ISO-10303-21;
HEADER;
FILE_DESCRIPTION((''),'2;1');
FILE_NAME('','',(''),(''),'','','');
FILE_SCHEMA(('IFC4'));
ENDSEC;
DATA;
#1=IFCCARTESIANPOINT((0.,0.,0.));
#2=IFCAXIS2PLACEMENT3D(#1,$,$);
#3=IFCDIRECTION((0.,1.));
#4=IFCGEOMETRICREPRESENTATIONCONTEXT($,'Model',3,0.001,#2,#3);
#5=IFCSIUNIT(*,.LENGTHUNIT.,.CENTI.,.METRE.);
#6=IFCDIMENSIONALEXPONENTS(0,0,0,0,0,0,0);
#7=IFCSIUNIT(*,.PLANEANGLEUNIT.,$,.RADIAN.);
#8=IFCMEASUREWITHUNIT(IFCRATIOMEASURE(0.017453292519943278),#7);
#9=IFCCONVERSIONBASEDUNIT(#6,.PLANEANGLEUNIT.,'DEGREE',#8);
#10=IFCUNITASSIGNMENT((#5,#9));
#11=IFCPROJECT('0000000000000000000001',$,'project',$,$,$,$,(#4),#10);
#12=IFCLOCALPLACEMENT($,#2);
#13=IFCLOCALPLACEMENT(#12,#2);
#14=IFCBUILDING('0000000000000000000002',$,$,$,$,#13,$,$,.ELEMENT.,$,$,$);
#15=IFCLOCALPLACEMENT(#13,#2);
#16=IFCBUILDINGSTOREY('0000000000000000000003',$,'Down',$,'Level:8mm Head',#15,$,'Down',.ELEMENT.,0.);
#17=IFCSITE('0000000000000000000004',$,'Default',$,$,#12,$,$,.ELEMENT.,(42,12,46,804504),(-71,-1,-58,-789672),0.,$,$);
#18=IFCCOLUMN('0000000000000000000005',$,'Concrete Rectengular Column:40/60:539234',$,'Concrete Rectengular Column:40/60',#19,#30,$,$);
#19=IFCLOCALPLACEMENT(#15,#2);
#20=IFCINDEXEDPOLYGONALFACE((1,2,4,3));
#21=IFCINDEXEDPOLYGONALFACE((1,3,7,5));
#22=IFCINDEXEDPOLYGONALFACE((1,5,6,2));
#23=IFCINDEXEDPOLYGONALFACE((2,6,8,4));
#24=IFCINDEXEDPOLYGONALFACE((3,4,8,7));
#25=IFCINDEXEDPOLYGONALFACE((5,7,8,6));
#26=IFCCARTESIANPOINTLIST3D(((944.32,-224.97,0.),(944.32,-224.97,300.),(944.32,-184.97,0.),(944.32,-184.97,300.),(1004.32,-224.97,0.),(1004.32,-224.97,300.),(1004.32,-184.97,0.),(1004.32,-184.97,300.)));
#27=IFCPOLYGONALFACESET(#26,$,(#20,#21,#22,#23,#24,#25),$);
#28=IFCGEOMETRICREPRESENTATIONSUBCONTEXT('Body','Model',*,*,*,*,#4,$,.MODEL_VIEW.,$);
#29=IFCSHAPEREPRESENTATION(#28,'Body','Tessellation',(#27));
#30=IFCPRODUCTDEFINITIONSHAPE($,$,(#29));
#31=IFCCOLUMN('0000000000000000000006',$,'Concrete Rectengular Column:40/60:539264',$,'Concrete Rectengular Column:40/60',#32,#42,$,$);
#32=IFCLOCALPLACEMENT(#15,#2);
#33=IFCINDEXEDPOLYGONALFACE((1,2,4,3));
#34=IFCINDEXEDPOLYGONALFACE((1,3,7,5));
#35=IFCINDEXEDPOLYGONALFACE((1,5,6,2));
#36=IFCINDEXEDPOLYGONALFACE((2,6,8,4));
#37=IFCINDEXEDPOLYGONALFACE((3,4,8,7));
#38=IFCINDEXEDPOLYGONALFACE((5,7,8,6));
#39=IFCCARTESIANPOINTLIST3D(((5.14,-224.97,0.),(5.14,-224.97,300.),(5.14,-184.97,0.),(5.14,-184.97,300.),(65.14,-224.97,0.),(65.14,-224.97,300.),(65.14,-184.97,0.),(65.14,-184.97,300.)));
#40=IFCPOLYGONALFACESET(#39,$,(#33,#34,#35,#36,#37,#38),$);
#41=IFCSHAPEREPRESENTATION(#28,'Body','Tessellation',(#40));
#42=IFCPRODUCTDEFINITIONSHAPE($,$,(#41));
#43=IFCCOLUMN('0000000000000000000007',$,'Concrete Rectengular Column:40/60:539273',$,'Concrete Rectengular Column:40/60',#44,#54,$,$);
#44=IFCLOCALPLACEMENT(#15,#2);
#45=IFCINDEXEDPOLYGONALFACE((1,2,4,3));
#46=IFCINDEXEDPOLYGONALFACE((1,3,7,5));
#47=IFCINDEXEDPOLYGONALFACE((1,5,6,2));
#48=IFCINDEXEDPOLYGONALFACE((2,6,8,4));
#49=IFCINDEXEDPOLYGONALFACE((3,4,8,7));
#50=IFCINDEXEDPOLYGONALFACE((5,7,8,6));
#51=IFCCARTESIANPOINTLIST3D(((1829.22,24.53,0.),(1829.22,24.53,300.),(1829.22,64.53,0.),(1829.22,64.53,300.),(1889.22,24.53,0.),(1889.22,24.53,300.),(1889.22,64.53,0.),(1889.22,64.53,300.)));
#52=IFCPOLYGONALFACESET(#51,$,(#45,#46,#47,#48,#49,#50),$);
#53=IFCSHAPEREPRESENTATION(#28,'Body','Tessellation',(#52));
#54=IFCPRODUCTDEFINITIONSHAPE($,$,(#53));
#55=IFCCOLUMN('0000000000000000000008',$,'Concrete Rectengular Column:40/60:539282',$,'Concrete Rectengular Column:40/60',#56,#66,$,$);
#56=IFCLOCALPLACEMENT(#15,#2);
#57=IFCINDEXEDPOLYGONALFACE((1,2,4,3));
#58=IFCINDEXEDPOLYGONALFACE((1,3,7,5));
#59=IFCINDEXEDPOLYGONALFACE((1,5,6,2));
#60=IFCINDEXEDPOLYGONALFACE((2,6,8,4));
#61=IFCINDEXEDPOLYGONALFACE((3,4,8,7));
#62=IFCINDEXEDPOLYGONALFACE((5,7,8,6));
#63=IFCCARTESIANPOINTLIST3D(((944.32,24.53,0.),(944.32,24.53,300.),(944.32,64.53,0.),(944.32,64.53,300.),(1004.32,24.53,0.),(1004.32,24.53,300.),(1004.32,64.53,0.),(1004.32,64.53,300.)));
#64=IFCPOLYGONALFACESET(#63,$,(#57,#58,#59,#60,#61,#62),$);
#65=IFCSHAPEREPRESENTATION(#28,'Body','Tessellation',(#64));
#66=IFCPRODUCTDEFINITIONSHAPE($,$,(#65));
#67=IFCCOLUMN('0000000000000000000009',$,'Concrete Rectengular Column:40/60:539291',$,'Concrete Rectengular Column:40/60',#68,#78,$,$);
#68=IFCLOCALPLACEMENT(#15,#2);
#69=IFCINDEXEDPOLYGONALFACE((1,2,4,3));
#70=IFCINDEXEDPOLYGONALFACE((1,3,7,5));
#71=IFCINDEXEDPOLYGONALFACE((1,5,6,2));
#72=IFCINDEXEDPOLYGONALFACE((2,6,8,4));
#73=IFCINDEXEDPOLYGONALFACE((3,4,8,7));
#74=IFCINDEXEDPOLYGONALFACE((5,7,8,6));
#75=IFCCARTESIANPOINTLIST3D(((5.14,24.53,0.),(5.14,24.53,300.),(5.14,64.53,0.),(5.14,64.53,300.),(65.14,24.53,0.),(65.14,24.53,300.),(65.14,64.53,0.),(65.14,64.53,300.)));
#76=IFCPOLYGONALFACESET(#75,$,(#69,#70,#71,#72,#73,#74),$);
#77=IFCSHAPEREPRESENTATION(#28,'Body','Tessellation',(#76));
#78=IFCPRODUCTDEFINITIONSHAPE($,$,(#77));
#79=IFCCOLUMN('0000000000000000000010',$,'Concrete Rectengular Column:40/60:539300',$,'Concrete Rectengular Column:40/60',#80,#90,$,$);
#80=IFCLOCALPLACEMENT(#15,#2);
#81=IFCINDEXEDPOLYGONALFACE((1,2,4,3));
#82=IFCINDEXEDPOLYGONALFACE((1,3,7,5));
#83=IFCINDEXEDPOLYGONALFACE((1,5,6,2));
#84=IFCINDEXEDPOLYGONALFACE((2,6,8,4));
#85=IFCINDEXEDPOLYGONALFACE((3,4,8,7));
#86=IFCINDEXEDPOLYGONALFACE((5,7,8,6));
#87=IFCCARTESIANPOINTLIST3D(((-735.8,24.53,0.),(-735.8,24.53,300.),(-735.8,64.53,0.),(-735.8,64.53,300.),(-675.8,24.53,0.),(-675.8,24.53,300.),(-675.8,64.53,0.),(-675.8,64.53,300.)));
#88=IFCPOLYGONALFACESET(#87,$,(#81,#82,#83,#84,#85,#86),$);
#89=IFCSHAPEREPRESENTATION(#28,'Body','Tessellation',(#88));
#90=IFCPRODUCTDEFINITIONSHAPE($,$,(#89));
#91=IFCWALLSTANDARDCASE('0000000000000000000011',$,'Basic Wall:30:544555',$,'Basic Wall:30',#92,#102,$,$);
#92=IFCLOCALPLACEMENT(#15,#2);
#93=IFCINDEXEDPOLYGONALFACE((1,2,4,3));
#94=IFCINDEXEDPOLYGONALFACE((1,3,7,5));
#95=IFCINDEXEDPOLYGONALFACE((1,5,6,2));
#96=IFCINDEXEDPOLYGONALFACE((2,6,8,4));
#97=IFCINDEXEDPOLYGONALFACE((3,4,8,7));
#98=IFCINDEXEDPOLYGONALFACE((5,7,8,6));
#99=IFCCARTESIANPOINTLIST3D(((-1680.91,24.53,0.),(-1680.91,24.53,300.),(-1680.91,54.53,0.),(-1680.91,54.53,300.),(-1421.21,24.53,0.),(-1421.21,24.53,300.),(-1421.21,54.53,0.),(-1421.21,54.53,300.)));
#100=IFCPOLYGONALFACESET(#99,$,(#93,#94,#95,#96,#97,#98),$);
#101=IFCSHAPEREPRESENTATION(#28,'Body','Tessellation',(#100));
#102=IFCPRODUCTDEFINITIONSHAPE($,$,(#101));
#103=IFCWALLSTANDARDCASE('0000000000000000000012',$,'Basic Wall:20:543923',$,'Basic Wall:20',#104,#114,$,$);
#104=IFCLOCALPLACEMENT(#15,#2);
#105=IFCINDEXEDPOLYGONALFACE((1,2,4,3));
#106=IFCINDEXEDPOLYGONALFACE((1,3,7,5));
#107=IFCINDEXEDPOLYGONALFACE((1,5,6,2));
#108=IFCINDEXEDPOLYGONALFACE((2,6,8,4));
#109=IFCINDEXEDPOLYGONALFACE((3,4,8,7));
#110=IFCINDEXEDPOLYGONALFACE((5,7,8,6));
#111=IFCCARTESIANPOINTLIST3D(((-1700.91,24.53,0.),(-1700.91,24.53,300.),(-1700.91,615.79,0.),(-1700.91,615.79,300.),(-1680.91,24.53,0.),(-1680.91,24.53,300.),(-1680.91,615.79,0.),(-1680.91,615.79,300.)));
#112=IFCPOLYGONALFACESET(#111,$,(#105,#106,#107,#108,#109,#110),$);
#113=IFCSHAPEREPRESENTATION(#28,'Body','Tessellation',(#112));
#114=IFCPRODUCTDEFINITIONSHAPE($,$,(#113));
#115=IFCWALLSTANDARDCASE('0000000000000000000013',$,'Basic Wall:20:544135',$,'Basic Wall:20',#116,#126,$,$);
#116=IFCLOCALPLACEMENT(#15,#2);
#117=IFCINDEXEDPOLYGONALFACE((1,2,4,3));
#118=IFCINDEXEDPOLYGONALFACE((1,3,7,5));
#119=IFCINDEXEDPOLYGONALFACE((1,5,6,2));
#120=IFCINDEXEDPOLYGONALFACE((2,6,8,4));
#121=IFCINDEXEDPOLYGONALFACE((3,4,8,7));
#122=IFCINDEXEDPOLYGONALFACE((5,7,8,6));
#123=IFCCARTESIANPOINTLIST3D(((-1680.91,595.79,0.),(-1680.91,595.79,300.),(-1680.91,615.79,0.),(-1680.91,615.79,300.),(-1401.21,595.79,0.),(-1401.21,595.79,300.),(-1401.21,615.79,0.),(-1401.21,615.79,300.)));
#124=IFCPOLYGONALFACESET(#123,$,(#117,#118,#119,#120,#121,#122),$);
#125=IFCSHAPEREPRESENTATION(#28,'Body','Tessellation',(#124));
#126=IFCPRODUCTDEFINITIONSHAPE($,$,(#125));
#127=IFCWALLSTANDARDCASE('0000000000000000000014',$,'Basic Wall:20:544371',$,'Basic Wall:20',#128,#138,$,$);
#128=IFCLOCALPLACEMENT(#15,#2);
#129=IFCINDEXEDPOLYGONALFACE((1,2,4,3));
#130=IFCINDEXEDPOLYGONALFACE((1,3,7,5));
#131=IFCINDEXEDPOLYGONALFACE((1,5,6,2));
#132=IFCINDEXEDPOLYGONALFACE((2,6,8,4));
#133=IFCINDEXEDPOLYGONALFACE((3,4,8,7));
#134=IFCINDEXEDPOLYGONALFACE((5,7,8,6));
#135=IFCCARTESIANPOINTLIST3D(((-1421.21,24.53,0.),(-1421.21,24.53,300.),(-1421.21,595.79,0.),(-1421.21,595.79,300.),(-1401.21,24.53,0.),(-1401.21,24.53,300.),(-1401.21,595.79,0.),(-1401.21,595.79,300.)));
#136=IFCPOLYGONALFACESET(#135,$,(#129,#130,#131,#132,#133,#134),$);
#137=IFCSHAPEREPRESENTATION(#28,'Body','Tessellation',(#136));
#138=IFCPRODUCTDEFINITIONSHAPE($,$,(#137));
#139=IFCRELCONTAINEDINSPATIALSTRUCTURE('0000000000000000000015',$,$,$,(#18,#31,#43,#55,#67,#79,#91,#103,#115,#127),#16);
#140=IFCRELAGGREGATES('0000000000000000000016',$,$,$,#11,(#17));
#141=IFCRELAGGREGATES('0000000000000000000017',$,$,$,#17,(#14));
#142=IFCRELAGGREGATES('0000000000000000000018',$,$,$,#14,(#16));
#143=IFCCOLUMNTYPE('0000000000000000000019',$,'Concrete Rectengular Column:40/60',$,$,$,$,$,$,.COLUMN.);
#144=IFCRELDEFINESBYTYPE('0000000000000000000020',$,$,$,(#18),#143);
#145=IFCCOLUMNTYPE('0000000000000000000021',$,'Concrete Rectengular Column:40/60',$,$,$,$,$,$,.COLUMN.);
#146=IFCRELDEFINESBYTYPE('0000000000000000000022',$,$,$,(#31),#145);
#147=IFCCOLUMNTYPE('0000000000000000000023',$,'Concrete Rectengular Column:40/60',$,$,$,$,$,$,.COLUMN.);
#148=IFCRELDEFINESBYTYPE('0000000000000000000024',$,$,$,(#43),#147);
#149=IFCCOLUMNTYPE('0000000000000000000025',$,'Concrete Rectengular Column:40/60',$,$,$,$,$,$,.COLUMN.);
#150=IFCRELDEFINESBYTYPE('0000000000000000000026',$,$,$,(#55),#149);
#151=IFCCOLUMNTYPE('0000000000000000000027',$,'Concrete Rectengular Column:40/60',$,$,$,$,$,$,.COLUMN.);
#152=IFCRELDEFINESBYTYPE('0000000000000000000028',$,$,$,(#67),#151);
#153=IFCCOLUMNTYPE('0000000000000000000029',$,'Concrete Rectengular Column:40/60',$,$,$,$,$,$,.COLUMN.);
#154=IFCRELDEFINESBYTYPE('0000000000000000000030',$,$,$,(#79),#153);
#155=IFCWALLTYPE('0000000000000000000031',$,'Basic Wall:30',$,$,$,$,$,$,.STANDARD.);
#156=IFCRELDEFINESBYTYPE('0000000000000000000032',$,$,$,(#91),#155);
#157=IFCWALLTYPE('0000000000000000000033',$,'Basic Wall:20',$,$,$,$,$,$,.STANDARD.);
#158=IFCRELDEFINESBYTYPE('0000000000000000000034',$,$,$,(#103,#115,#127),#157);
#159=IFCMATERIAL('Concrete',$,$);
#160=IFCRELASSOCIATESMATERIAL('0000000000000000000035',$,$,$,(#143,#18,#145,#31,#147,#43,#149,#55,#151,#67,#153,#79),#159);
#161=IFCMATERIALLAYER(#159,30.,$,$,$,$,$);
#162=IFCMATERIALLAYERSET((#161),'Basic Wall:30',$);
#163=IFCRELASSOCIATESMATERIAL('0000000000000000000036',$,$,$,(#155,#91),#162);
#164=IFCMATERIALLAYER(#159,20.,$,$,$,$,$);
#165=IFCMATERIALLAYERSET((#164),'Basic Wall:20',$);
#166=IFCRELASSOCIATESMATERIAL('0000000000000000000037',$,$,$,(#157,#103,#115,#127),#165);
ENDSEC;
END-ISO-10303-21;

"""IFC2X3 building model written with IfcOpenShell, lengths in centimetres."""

from ifc_helpers import new_model, entity, si_unit, converted_unit, direction, frame, frame_2d, origin, origin_2d_with_axis, place, context, subcontext, project, spatial, rectangle, extrude, source, transform, mapped, material, layer, layer_set, layer_usage, type_object, type_shapes, element, save


model = new_model("IFC2X3")

# Units and contexts
model_context = context("Model", 3, precision=0.001, world=origin(), true_north=direction((0.0, 1.0)))
body_context = subcontext(model_context, "Body", "Model", "MODEL_VIEW")
ifc_project = project(units=[si_unit("LENGTHUNIT", "METRE", prefix="CENTI"), converted_unit("PLANEANGLEUNIT", "DEGREE", entity("IfcRatioMeasure", 0.017453292519943278), si_unit("PLANEANGLEUNIT", "RADIAN"), dimensions=[0, 0, 0, 0, 0, 0, 0])], contexts=[model_context])

# Site, building, storey
site_placement = place(None, origin())
site = spatial("IfcSite", under=ifc_project, at=site_placement, Name="Default", CompositionType="ELEMENT", RefLatitude=(42, 12, 46, 804504), RefLongitude=(-71, -1, -58, -789672), RefElevation=0.0)
building_placement = place(site_placement, origin())
building = spatial("IfcBuilding", under=site, at=building_placement, CompositionType="ELEMENT")
storey_placement = place(building_placement, origin())
storey = spatial("IfcBuildingStorey", under=building, at=storey_placement, Name="Down", ObjectType="Level:8mm Head", LongName="Down", CompositionType="ELEMENT", Elevation=0.0)

# Columns
ifc_material = material(Name="Concrete")
column_type_1 = type_object("IfcColumnType", Name="Concrete Rectengular Column:40/60", PredefinedType="COLUMN", material=ifc_material)
shared_shape_1 = source(origin(), body_context, "Body", "SweptSolid", [
    extrude(rectangle(XDim=40.0, YDim=60.0, at=origin_2d_with_axis()), frame((974.32, -204.97, 0.0), z_axis=(0.0, 0.0, 1.0), x_axis=(0.0, -1.0, 0.0)), (0.0, 0.0, 1.0), 300.0),
])
type_shapes(column_type_1, [shared_shape_1])
column_1_placement = place(storey_placement, origin())
element("IfcColumn", 1, at=column_1_placement, inside=storey, type_object=column_type_1, material=ifc_material, Name="Concrete Rectengular Column:40/60:539234", ObjectType="Concrete Rectengular Column:40/60", context=body_context, shape_type="MappedRepresentation", body=[
    mapped(shared_shape_1, transform((0.0, 0.0, 0.0), scale=1.0)),
])
column_type_2 = type_object("IfcColumnType", Name="Concrete Rectengular Column:40/60", PredefinedType="COLUMN", material=ifc_material)
shared_shape_2 = source(origin(), body_context, "Body", "SweptSolid", [
    extrude(rectangle(XDim=40.0, YDim=60.0, at=frame_2d((0.0, 0.0), x_axis=(1.0, 0.0))), frame((35.14, -204.97, 0.0), z_axis=(0.0, 0.0, 1.0), x_axis=(0.0, -1.0, 0.0)), (0.0, 0.0, 1.0), 300.0),
])
type_shapes(column_type_2, [shared_shape_2])
column_2_placement = place(storey_placement, origin())
element("IfcColumn", 2, at=column_2_placement, inside=storey, type_object=column_type_2, material=ifc_material, Name="Concrete Rectengular Column:40/60:539264", ObjectType="Concrete Rectengular Column:40/60", context=body_context, shape_type="MappedRepresentation", body=[
    mapped(shared_shape_2, transform((0.0, 0.0, 0.0), scale=1.0)),
])
column_type_3 = type_object("IfcColumnType", Name="Concrete Rectengular Column:40/60", PredefinedType="COLUMN", material=ifc_material)
shared_shape_3 = source(origin(), body_context, "Body", "SweptSolid", [
    extrude(rectangle(XDim=40.0, YDim=60.0, at=frame_2d((0.0, 0.0), x_axis=(1.0, 0.0))), frame((1859.22, 44.53, 0.0), z_axis=(0.0, 0.0, 1.0), x_axis=(0.0, -1.0, 0.0)), (0.0, 0.0, 1.0), 300.0),
])
type_shapes(column_type_3, [shared_shape_3])
column_3_placement = place(storey_placement, origin())
element("IfcColumn", 3, at=column_3_placement, inside=storey, type_object=column_type_3, material=ifc_material, Name="Concrete Rectengular Column:40/60:539273", ObjectType="Concrete Rectengular Column:40/60", context=body_context, shape_type="MappedRepresentation", body=[
    mapped(shared_shape_3, transform((0.0, 0.0, 0.0), scale=1.0)),
])
column_type_4 = type_object("IfcColumnType", Name="Concrete Rectengular Column:40/60", PredefinedType="COLUMN", material=ifc_material)
shared_shape_4 = source(origin(), body_context, "Body", "SweptSolid", [
    extrude(rectangle(XDim=40.0, YDim=60.0, at=frame_2d((0.0, 0.0), x_axis=(1.0, 0.0))), frame((974.32, 44.53, 0.0), z_axis=(0.0, 0.0, 1.0), x_axis=(0.0, -1.0, 0.0)), (0.0, 0.0, 1.0), 300.0),
])
type_shapes(column_type_4, [shared_shape_4])
column_4_placement = place(storey_placement, origin())
element("IfcColumn", 4, at=column_4_placement, inside=storey, type_object=column_type_4, material=ifc_material, Name="Concrete Rectengular Column:40/60:539282", ObjectType="Concrete Rectengular Column:40/60", context=body_context, shape_type="MappedRepresentation", body=[
    mapped(shared_shape_4, transform((0.0, 0.0, 0.0), scale=1.0)),
])
column_type_5 = type_object("IfcColumnType", Name="Concrete Rectengular Column:40/60", PredefinedType="COLUMN", material=ifc_material)
shared_shape_5 = source(origin(), body_context, "Body", "SweptSolid", [
    extrude(rectangle(XDim=40.0, YDim=60.0, at=frame_2d((0.0, 0.0), x_axis=(1.0, 0.0))), frame((35.14, 44.53, 0.0), z_axis=(0.0, 0.0, 1.0), x_axis=(0.0, -1.0, 0.0)), (0.0, 0.0, 1.0), 300.0),
])
type_shapes(column_type_5, [shared_shape_5])
column_5_placement = place(storey_placement, origin())
element("IfcColumn", 5, at=column_5_placement, inside=storey, type_object=column_type_5, material=ifc_material, Name="Concrete Rectengular Column:40/60:539291", ObjectType="Concrete Rectengular Column:40/60", context=body_context, shape_type="MappedRepresentation", body=[
    mapped(shared_shape_5, transform((0.0, 0.0, 0.0), scale=1.0)),
])
column_type_6 = type_object("IfcColumnType", Name="Concrete Rectengular Column:40/60", PredefinedType="COLUMN", material=ifc_material)
shared_shape_6 = source(origin(), body_context, "Body", "SweptSolid", [
    extrude(rectangle(XDim=40.0, YDim=60.0, at=origin_2d_with_axis()), frame((-705.8, 44.53, 0.0), z_axis=(0.0, 0.0, 1.0), x_axis=(0.0, -1.0, 0.0)), (0.0, 0.0, 1.0), 300.0),
])
type_shapes(column_type_6, [shared_shape_6])
column_6_placement = place(storey_placement, origin())
element("IfcColumn", 6, at=column_6_placement, inside=storey, type_object=column_type_6, material=ifc_material, Name="Concrete Rectengular Column:40/60:539300", ObjectType="Concrete Rectengular Column:40/60", context=body_context, shape_type="MappedRepresentation", body=[
    mapped(shared_shape_6, transform((0.0, 0.0, 0.0), scale=1.0)),
])

# Walls
ifc_layer_1 = layer(ifc_material, 30.0)
ifc_layer_set_1 = layer_set([ifc_layer_1], Name="Basic Wall:30")
ifc_layer_usage_1 = layer_usage(ifc_layer_set_1, "AXIS2", "NEGATIVE", 15.0)
wall_type_1 = type_object("IfcWallType", Name="Basic Wall:30", PredefinedType="STANDARD", material=ifc_layer_set_1)
wall_1_placement = place(storey_placement, frame((-1421.21, 39.53, 0.0), z_axis=(0.0, 0.0, 1.0), x_axis=(-1.0, 0.0, 0.0)))
element("IfcWallStandardCase", 7, at=wall_1_placement, inside=storey, type_object=wall_type_1, material=ifc_layer_usage_1, Name="Basic Wall:30:544555", ObjectType="Basic Wall:30", context=body_context, shape_type="SweptSolid", body=[
    extrude(rectangle(XDim=259.7, YDim=30.0, at=frame_2d((129.85, 0.0), x_axis=(-1.0, 0.0))), origin(), (0.0, 0.0, 1.0), 300.0),
])
ifc_layer_2 = layer(ifc_material, 20.0)
ifc_layer_set_2 = layer_set([ifc_layer_2], Name="Basic Wall:20")
ifc_layer_usage_2 = layer_usage(ifc_layer_set_2, "AXIS2", "NEGATIVE", 10.0)
wall_type_2 = type_object("IfcWallType", Name="Basic Wall:20", PredefinedType="STANDARD", material=ifc_layer_set_2)
wall_2_placement = place(storey_placement, frame((-1690.91, 24.53, 0.0), z_axis=(0.0, 0.0, 1.0), x_axis=(0.0, 1.0, 0.0)))
element("IfcWallStandardCase", 8, at=wall_2_placement, inside=storey, type_object=wall_type_2, material=ifc_layer_usage_2, Name="Basic Wall:20:543923", ObjectType="Basic Wall:20", context=body_context, shape_type="SweptSolid", body=[
    extrude(rectangle(XDim=591.25, YDim=20.0, at=frame_2d((295.63, 0.0), x_axis=(-1.0, 0.0))), origin(), (0.0, 0.0, 1.0), 300.0),
])
ifc_layer_usage_3 = layer_usage(ifc_layer_set_2, "AXIS2", "NEGATIVE", 10.0)
wall_3_placement = place(storey_placement, frame((-1680.91, 605.79, 0.0)))
element("IfcWallStandardCase", 9, at=wall_3_placement, inside=storey, type_object=wall_type_2, material=ifc_layer_usage_3, Name="Basic Wall:20:544135", ObjectType="Basic Wall:20", context=body_context, shape_type="SweptSolid", body=[
    extrude(rectangle(XDim=279.7, YDim=20.0, at=frame_2d((139.85, 0.0), x_axis=(-1.0, 0.0))), origin(), (0.0, 0.0, 1.0), 300.0),
])
ifc_layer_usage_4 = layer_usage(ifc_layer_set_2, "AXIS2", "NEGATIVE", 10.0)
wall_4_placement = place(storey_placement, frame((-1411.21, 595.79, 0.0), z_axis=(0.0, 0.0, 1.0), x_axis=(0.0, -1.0, 0.0)))
element("IfcWallStandardCase", 10, at=wall_4_placement, inside=storey, type_object=wall_type_2, material=ifc_layer_usage_4, Name="Basic Wall:20:544371", ObjectType="Basic Wall:20", context=body_context, shape_type="SweptSolid", body=[
    extrude(rectangle(XDim=571.25, YDim=20.0, at=frame_2d((285.63, 0.0), x_axis=(-1.0, 0.0))), origin(), (0.0, 0.0, 1.0), 300.0),
])

save(model, "model.ifc")
